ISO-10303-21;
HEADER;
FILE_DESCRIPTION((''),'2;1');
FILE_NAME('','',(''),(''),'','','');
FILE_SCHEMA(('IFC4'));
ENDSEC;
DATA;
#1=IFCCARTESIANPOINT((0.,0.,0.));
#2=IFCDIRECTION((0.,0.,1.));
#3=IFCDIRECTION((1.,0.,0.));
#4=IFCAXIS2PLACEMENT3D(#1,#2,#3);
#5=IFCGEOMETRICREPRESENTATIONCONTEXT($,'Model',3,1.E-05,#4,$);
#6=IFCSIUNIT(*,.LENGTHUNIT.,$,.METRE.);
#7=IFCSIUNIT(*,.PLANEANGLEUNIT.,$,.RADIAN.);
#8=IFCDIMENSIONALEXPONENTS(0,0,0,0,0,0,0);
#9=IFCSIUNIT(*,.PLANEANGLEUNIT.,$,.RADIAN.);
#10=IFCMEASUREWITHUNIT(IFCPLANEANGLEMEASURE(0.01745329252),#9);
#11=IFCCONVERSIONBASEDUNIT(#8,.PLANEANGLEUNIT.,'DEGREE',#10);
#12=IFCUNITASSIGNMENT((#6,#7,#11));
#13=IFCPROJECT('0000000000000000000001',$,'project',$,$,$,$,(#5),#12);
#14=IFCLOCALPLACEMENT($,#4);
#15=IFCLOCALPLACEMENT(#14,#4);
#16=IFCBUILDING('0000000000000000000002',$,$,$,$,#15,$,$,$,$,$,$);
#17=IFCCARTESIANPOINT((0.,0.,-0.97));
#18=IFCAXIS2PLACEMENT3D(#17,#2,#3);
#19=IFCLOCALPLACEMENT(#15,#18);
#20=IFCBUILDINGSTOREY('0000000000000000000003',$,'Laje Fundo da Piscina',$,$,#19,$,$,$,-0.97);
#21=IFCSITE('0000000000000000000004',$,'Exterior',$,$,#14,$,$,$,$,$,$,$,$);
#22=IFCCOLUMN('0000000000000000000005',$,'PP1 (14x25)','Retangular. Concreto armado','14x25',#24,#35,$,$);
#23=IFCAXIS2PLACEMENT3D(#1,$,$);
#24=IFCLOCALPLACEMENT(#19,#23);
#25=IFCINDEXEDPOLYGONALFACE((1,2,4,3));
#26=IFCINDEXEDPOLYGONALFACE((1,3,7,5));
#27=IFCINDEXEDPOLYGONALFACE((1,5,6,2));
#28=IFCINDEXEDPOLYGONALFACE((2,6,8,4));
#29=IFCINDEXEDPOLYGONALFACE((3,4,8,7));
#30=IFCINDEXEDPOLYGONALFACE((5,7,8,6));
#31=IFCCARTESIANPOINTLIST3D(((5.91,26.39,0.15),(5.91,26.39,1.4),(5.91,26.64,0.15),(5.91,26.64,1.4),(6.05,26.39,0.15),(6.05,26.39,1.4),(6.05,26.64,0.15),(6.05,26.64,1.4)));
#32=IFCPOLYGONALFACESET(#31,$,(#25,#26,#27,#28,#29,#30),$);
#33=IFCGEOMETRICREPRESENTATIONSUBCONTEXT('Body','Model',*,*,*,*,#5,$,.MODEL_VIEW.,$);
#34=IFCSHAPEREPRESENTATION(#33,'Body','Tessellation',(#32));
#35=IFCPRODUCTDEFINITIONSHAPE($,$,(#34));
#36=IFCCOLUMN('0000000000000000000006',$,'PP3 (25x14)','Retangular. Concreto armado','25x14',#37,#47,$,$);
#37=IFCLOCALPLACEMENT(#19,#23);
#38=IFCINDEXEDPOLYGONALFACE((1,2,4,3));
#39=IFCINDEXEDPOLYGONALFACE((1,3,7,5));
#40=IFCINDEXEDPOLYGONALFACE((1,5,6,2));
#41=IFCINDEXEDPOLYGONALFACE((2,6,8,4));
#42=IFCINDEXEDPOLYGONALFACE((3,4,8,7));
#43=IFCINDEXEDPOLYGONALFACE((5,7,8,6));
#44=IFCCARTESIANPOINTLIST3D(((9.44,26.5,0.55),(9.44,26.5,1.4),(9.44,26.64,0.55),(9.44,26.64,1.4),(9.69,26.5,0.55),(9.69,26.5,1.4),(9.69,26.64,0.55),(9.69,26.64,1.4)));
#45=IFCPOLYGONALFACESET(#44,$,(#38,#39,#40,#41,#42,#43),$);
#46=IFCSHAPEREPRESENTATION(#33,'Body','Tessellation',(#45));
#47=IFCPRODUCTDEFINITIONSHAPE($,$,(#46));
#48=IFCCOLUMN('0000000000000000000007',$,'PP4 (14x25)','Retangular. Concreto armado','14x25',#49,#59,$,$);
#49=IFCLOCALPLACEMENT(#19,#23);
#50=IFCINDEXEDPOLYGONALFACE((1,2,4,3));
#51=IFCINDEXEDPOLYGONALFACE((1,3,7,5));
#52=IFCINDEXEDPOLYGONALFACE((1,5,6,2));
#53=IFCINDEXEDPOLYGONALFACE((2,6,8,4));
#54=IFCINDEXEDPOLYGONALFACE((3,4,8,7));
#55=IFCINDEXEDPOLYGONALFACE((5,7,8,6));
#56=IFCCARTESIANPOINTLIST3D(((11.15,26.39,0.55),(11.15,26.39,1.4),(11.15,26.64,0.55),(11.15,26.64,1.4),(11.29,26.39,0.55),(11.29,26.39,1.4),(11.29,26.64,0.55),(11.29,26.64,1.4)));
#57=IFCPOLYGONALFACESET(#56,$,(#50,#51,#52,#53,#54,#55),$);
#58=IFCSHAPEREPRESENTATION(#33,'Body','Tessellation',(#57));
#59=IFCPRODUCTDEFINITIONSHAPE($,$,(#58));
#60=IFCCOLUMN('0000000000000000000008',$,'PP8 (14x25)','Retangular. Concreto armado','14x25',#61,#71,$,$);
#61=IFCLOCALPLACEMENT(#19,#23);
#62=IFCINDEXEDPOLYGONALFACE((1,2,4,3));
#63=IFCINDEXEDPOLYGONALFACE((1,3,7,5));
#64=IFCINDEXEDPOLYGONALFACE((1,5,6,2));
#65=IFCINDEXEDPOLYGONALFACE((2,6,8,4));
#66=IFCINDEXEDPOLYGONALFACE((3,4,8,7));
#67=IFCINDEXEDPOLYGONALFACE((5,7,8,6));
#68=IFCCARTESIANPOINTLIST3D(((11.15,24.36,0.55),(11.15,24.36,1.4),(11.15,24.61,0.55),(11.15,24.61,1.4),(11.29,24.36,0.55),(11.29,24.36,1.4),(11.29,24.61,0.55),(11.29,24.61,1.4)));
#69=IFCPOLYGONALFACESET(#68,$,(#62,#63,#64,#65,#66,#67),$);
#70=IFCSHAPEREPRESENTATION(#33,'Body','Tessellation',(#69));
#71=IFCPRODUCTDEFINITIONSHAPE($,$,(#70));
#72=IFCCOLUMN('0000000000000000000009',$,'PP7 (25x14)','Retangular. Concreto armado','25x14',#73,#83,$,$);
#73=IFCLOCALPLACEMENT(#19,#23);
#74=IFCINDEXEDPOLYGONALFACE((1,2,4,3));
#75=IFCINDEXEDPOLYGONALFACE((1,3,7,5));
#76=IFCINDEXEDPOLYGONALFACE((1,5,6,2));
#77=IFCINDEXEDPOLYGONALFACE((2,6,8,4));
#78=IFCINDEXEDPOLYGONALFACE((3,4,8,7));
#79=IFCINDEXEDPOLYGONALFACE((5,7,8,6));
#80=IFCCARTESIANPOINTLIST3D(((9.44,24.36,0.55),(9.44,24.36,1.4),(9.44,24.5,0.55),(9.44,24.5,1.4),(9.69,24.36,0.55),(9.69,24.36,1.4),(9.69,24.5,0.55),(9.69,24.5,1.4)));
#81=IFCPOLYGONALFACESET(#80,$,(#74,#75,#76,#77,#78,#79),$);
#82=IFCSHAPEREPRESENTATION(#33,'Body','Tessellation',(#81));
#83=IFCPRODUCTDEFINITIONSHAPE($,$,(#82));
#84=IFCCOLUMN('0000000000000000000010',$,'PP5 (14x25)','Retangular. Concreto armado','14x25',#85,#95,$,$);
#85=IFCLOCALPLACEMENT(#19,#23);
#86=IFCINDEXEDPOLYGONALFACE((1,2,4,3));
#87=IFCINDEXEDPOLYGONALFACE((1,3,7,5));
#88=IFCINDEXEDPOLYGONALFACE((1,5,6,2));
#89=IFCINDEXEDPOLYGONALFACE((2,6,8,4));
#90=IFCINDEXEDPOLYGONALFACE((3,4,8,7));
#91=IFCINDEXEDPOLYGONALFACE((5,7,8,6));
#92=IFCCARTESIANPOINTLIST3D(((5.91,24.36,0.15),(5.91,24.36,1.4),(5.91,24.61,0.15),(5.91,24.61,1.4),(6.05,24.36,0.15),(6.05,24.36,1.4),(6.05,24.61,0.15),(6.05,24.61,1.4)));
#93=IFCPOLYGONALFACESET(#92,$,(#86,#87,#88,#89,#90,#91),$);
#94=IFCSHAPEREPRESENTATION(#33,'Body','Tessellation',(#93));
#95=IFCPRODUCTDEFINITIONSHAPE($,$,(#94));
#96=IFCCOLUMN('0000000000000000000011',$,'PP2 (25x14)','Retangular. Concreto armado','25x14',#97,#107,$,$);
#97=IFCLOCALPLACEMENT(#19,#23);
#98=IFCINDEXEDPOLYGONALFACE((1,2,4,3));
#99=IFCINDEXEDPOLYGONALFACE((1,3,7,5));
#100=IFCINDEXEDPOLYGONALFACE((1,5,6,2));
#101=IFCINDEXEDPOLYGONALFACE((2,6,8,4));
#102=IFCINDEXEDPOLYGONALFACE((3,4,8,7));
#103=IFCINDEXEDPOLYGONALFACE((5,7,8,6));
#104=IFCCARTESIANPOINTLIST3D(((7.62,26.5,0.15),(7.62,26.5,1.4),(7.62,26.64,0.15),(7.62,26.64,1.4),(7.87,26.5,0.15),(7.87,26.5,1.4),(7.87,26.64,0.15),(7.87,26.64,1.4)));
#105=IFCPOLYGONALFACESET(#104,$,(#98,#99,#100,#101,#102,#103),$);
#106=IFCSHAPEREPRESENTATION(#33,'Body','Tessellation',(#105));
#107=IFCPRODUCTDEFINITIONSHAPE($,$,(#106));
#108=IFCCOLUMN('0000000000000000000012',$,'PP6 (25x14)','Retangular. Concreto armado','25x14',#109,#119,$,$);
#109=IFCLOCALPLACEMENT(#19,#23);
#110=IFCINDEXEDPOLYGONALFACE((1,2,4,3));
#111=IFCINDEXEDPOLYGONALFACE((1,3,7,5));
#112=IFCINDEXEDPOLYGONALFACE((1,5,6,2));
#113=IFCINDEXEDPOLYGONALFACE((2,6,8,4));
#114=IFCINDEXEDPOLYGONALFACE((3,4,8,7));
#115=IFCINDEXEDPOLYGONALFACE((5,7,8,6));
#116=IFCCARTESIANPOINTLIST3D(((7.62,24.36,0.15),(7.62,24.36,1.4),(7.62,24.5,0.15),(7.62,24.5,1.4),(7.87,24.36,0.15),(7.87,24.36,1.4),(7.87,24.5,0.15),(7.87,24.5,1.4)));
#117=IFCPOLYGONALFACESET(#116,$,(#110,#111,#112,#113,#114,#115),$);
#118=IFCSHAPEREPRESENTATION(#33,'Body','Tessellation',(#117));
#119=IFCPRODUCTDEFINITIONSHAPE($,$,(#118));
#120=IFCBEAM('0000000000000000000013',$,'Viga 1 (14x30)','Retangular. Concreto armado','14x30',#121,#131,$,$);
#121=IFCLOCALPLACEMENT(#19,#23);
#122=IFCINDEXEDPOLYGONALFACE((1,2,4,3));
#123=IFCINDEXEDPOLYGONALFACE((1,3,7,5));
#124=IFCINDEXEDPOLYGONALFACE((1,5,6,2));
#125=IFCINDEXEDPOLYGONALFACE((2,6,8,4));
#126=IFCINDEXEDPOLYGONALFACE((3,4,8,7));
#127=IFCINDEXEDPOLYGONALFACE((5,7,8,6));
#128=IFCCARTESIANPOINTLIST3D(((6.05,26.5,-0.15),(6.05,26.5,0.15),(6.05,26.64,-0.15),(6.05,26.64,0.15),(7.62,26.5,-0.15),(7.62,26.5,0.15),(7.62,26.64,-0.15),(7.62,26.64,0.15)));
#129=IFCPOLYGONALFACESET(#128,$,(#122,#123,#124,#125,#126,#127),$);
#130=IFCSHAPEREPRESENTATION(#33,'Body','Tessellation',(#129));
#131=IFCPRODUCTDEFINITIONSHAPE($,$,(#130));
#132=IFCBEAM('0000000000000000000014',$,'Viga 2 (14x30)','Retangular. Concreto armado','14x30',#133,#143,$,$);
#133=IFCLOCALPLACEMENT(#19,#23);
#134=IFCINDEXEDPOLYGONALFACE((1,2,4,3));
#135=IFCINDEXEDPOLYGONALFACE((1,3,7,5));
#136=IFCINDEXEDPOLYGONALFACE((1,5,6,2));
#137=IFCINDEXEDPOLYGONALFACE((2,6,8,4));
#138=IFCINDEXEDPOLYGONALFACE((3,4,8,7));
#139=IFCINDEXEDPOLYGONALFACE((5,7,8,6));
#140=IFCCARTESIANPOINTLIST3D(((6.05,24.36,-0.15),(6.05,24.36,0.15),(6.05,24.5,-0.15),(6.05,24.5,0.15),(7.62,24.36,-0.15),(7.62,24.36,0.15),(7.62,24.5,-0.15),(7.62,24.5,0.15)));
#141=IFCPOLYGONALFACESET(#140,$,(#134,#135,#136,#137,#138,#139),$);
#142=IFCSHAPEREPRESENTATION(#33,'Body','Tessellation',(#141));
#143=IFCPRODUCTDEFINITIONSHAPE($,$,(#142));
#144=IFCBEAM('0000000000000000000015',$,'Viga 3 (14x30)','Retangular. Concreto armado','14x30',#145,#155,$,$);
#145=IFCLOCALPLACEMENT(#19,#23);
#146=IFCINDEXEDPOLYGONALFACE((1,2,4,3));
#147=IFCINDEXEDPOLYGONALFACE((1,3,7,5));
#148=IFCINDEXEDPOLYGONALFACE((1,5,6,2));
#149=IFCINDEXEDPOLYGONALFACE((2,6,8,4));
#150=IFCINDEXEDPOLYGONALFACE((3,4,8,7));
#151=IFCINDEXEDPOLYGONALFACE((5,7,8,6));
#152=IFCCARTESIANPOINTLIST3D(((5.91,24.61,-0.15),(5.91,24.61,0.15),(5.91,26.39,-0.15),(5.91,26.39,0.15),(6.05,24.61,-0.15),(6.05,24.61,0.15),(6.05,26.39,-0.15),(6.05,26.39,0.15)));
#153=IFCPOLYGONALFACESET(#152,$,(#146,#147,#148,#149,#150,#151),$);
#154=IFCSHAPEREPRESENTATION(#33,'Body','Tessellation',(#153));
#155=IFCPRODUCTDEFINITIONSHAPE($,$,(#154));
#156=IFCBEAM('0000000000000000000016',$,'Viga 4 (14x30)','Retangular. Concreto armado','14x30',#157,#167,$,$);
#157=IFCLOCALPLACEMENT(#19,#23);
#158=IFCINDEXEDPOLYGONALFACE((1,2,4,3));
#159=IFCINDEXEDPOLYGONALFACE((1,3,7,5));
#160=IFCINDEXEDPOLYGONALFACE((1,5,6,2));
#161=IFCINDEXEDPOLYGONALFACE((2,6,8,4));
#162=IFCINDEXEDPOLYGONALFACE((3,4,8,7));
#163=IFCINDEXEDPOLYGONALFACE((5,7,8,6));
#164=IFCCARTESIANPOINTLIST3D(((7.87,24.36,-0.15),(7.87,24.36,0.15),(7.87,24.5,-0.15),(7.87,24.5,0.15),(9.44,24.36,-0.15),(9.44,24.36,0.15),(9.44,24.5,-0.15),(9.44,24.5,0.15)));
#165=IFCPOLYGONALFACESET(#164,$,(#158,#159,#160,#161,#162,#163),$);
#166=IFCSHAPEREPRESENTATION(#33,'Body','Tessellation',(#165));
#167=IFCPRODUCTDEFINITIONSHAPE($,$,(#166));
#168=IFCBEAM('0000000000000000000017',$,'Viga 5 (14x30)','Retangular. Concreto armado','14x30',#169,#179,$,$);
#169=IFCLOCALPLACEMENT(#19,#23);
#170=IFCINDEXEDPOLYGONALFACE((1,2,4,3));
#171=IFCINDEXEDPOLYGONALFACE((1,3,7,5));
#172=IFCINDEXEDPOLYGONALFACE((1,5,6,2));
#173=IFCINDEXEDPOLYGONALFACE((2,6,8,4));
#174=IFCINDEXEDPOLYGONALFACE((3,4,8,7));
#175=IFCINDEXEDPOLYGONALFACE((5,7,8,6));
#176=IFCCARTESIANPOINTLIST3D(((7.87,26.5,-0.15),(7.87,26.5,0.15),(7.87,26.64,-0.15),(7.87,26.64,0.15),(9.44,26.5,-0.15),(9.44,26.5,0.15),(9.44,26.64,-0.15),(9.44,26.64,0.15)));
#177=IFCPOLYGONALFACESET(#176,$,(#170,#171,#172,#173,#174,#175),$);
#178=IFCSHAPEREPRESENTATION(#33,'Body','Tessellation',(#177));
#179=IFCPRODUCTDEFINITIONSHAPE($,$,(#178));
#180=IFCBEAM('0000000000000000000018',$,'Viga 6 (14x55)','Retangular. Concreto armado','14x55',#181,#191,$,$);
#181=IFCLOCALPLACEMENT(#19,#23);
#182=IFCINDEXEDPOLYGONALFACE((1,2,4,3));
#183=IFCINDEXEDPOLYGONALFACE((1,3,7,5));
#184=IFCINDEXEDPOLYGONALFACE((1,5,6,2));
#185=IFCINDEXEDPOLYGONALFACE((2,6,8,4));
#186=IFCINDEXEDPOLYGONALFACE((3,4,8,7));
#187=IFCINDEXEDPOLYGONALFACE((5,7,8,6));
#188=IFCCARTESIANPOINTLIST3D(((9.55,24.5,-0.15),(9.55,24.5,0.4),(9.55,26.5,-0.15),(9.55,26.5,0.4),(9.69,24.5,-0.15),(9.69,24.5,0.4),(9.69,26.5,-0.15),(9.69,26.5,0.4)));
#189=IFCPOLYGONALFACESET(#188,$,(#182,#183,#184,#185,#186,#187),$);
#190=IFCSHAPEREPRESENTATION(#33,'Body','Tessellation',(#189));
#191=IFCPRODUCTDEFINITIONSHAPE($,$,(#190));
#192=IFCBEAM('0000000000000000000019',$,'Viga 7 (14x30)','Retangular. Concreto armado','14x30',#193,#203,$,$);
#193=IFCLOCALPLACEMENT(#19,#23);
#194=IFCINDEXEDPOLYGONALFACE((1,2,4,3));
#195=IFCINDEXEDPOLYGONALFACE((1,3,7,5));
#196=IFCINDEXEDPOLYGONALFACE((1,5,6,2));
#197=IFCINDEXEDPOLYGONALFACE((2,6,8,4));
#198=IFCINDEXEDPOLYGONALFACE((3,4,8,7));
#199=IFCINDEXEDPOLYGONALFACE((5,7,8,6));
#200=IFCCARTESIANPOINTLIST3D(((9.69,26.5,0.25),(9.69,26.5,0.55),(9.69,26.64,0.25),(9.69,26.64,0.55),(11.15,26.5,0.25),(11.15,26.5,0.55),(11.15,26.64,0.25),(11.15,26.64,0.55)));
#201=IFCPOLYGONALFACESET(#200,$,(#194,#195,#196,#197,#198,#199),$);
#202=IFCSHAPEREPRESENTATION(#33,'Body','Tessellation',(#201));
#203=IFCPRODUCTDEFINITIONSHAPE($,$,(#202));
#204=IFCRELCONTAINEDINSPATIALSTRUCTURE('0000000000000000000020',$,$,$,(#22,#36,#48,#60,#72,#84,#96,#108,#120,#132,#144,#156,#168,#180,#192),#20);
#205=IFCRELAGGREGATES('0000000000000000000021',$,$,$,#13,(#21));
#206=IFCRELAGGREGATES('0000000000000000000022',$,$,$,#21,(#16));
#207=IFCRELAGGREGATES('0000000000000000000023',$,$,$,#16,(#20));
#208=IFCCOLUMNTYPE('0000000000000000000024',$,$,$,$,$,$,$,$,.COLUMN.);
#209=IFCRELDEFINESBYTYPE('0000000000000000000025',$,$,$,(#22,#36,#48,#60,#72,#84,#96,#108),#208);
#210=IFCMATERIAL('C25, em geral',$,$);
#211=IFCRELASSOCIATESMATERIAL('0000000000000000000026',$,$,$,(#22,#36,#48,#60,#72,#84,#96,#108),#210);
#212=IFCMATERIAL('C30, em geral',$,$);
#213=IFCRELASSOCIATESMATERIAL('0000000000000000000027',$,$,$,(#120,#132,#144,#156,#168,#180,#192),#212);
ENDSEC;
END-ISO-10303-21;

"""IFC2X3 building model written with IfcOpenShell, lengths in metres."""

from ifc_helpers import new_model, entity, si_unit, converted_unit, frame, frame_2d, origin_with_axes, place, context, subcontext, project, spatial, rectangle, extrude, material, type_object, element, save


model = new_model("IFC2X3")

# Units and contexts
model_context = context("Model", 3, precision=1e-05, world=origin_with_axes())
body_context = subcontext(model_context, "Body", "Model", "MODEL_VIEW")
ifc_project = project(units=[si_unit("LENGTHUNIT", "METRE"), si_unit("PLANEANGLEUNIT", "RADIAN"), converted_unit("PLANEANGLEUNIT", "DEGREE", entity("IfcPlaneAngleMeasure", 0.01745329252), si_unit("PLANEANGLEUNIT", "RADIAN"), dimensions=[0, 0, 0, 0, 0, 0, 0])], contexts=[model_context])

# Site, building, storey
site_placement = place(None, origin_with_axes())
site = spatial("IfcSite", under=ifc_project, at=site_placement, Name="Exterior")
building_placement = place(site_placement, origin_with_axes())
building = spatial("IfcBuilding", under=site, at=building_placement)
storey_placement = place(building_placement, frame((0.0, 0.0, -0.97), z_axis=(0.0, 0.0, 1.0), x_axis=(1.0, 0.0, 0.0)))
storey = spatial("IfcBuildingStorey", under=building, at=storey_placement, Name="Laje Fundo da Piscina", Elevation=-0.97)

# Columns
ifc_material_1 = material(Name="C25, em geral")
column_type = type_object("IfcColumnType", PredefinedType="COLUMN")
column_1_placement = place(storey_placement, frame((6.05, 26.64, 0.15), z_axis=(0.0, 0.0, 1.0), x_axis=(1.0, 0.0, 0.0)))
element("IfcColumn", 1, at=column_1_placement, inside=storey, type_object=column_type, material=ifc_material_1, Name="PP1 (14x25)", Description="Retangular. Concreto armado", ObjectType="14x25", context=body_context, shape_type="SweptSolid", body=[
    extrude(rectangle(XDim=0.14, YDim=0.25, at=frame_2d((-0.07, -0.125), x_axis=(1.0, 0.0))), origin_with_axes(), (0.0, 0.0, 1.0), 1.25),
])
column_2_placement = place(storey_placement, frame((9.69, 26.5, 0.55), z_axis=(0.0, 0.0, 1.0), x_axis=(1.0, 0.0, 0.0)))
element("IfcColumn", 2, at=column_2_placement, inside=storey, type_object=column_type, material=ifc_material_1, Name="PP3 (25x14)", Description="Retangular. Concreto armado", ObjectType="25x14", context=body_context, shape_type="SweptSolid", body=[
    extrude(rectangle(XDim=0.25, YDim=0.14, at=frame_2d((-0.125, 0.07), x_axis=(1.0, 0.0))), origin_with_axes(), (0.0, 0.0, 1.0), 0.85),
])
column_3_placement = place(storey_placement, frame((11.15, 26.64, 0.55), z_axis=(0.0, 0.0, 1.0), x_axis=(1.0, 0.0, 0.0)))
element("IfcColumn", 3, at=column_3_placement, inside=storey, type_object=column_type, material=ifc_material_1, Name="PP4 (14x25)", Description="Retangular. Concreto armado", ObjectType="14x25", context=body_context, shape_type="SweptSolid", body=[
    extrude(rectangle(XDim=0.14, YDim=0.25, at=frame_2d((0.07, -0.125), x_axis=(1.0, 0.0))), origin_with_axes(), (0.0, 0.0, 1.0), 0.85),
])
column_4_placement = place(storey_placement, frame((11.15, 24.36, 0.55), z_axis=(0.0, 0.0, 1.0), x_axis=(1.0, 0.0, 0.0)))
element("IfcColumn", 4, at=column_4_placement, inside=storey, type_object=column_type, material=ifc_material_1, Name="PP8 (14x25)", Description="Retangular. Concreto armado", ObjectType="14x25", context=body_context, shape_type="SweptSolid", body=[
    extrude(rectangle(XDim=0.14, YDim=0.25, at=frame_2d((0.07, 0.125), x_axis=(1.0, 0.0))), origin_with_axes(), (0.0, 0.0, 1.0), 0.85),
])
column_5_placement = place(storey_placement, frame((9.69, 24.5, 0.55), z_axis=(0.0, 0.0, 1.0), x_axis=(1.0, 0.0, 0.0)))
element("IfcColumn", 5, at=column_5_placement, inside=storey, type_object=column_type, material=ifc_material_1, Name="PP7 (25x14)", Description="Retangular. Concreto armado", ObjectType="25x14", context=body_context, shape_type="SweptSolid", body=[
    extrude(rectangle(XDim=0.25, YDim=0.14, at=frame_2d((-0.125, -0.07), x_axis=(1.0, 0.0))), origin_with_axes(), (0.0, 0.0, 1.0), 0.85),
])
column_6_placement = place(storey_placement, frame((6.05, 24.36, 0.15), z_axis=(0.0, 0.0, 1.0), x_axis=(1.0, 0.0, 0.0)))
element("IfcColumn", 6, at=column_6_placement, inside=storey, type_object=column_type, material=ifc_material_1, Name="PP5 (14x25)", Description="Retangular. Concreto armado", ObjectType="14x25", context=body_context, shape_type="SweptSolid", body=[
    extrude(rectangle(XDim=0.14, YDim=0.25, at=frame_2d((-0.07, 0.125), x_axis=(1.0, 0.0))), origin_with_axes(), (0.0, 0.0, 1.0), 1.25),
])
column_7_placement = place(storey_placement, frame((7.87, 26.5, 0.15), z_axis=(0.0, 0.0, 1.0), x_axis=(1.0, 0.0, 0.0)))
element("IfcColumn", 7, at=column_7_placement, inside=storey, type_object=column_type, material=ifc_material_1, Name="PP2 (25x14)", Description="Retangular. Concreto armado", ObjectType="25x14", context=body_context, shape_type="SweptSolid", body=[
    extrude(rectangle(XDim=0.25, YDim=0.14, at=frame_2d((-0.125, 0.07), x_axis=(1.0, 0.0))), origin_with_axes(), (0.0, 0.0, 1.0), 1.25),
])
column_8_placement = place(storey_placement, frame((7.87, 24.5, 0.15), z_axis=(0.0, 0.0, 1.0), x_axis=(1.0, 0.0, 0.0)))
element("IfcColumn", 8, at=column_8_placement, inside=storey, type_object=column_type, material=ifc_material_1, Name="PP6 (25x14)", Description="Retangular. Concreto armado", ObjectType="25x14", context=body_context, shape_type="SweptSolid", body=[
    extrude(rectangle(XDim=0.25, YDim=0.14, at=frame_2d((-0.125, -0.07), x_axis=(1.0, 0.0))), origin_with_axes(), (0.0, 0.0, 1.0), 1.25),
])

# Beams
ifc_material_2 = material(Name="C30, em geral")
for number, where, z_axis, x_axis, name in (
    (9, (7.62, 26.57, 0.15), (-1.0, 0.0, 0.0), (0.0, -1.0, 0.0), "Viga 1 (14x30)"),
    (10, (7.62, 24.43, 0.15), (-1.0, 0.0, 0.0), (0.0, -1.0, 0.0), "Viga 2 (14x30)"),
):
    element("IfcBeam", number, at=place(storey_placement, frame(where, z_axis=z_axis, x_axis=x_axis)), inside=storey, material=ifc_material_2, Name=name, Description="Retangular. Concreto armado", ObjectType="14x30", context=body_context, shape_type="SweptSolid", body=[
        extrude(rectangle(XDim=0.14, YDim=0.3, at=frame_2d((0.0, -0.15), x_axis=(1.0, 0.0))), origin_with_axes(), (0.0, 0.0, 1.0), 1.57),
    ])
beam_1_placement = place(storey_placement, frame((5.98, 24.61, 0.15), z_axis=(0.0, 1.0, 0.0), x_axis=(-1.0, 0.0, 0.0)))
element("IfcBeam", 11, at=beam_1_placement, inside=storey, material=ifc_material_2, Name="Viga 3 (14x30)", Description="Retangular. Concreto armado", ObjectType="14x30", context=body_context, shape_type="SweptSolid", body=[
    extrude(rectangle(XDim=0.14, YDim=0.3, at=frame_2d((0.0, -0.15), x_axis=(1.0, 0.0))), origin_with_axes(), (0.0, 0.0, 1.0), 1.78),
])
for number, where, z_axis, x_axis, name in (
    (12, (7.87, 24.43, 0.15), (1.0, 0.0, 0.0), (0.0, 1.0, 0.0), "Viga 4 (14x30)"),
    (13, (7.87, 26.57, 0.15), (1.0, 0.0, 0.0), (0.0, 1.0, 0.0), "Viga 5 (14x30)"),
):
    element("IfcBeam", number, at=place(storey_placement, frame(where, z_axis=z_axis, x_axis=x_axis)), inside=storey, material=ifc_material_2, Name=name, Description="Retangular. Concreto armado", ObjectType="14x30", context=body_context, shape_type="SweptSolid", body=[
        extrude(rectangle(XDim=0.14, YDim=0.3, at=frame_2d((0.0, -0.15), x_axis=(1.0, 0.0))), origin_with_axes(), (0.0, 0.0, 1.0), 1.57),
    ])
beam_2_placement = place(storey_placement, frame((9.62, 26.5, 0.4), z_axis=(0.0, -1.0, 0.0), x_axis=(1.0, 0.0, 0.0)))
element("IfcBeam", 14, at=beam_2_placement, inside=storey, material=ifc_material_2, Name="Viga 6 (14x55)", Description="Retangular. Concreto armado", ObjectType="14x55", context=body_context, shape_type="SweptSolid", body=[
    extrude(rectangle(XDim=0.14, YDim=0.55, at=frame_2d((0.0, -0.275), x_axis=(1.0, 0.0))), origin_with_axes(), (0.0, 0.0, 1.0), 2.0),
])
for number, where, z_axis, x_axis, name in (
    (15, (9.69, 26.57, 0.55), (1.0, 0.0, 0.0), (0.0, 1.0, 0.0), "Viga 7 (14x30)"),
):
    element("IfcBeam", number, at=place(storey_placement, frame(where, z_axis=z_axis, x_axis=x_axis)), inside=storey, material=ifc_material_2, Name=name, Description="Retangular. Concreto armado", ObjectType="14x30", context=body_context, shape_type="SweptSolid", body=[
        extrude(rectangle(XDim=0.14, YDim=0.3, at=frame_2d((0.0, -0.15), x_axis=(1.0, 0.0))), origin_with_axes(), (0.0, 0.0, 1.0), 1.46),
    ])

save(model, "model.ifc")
